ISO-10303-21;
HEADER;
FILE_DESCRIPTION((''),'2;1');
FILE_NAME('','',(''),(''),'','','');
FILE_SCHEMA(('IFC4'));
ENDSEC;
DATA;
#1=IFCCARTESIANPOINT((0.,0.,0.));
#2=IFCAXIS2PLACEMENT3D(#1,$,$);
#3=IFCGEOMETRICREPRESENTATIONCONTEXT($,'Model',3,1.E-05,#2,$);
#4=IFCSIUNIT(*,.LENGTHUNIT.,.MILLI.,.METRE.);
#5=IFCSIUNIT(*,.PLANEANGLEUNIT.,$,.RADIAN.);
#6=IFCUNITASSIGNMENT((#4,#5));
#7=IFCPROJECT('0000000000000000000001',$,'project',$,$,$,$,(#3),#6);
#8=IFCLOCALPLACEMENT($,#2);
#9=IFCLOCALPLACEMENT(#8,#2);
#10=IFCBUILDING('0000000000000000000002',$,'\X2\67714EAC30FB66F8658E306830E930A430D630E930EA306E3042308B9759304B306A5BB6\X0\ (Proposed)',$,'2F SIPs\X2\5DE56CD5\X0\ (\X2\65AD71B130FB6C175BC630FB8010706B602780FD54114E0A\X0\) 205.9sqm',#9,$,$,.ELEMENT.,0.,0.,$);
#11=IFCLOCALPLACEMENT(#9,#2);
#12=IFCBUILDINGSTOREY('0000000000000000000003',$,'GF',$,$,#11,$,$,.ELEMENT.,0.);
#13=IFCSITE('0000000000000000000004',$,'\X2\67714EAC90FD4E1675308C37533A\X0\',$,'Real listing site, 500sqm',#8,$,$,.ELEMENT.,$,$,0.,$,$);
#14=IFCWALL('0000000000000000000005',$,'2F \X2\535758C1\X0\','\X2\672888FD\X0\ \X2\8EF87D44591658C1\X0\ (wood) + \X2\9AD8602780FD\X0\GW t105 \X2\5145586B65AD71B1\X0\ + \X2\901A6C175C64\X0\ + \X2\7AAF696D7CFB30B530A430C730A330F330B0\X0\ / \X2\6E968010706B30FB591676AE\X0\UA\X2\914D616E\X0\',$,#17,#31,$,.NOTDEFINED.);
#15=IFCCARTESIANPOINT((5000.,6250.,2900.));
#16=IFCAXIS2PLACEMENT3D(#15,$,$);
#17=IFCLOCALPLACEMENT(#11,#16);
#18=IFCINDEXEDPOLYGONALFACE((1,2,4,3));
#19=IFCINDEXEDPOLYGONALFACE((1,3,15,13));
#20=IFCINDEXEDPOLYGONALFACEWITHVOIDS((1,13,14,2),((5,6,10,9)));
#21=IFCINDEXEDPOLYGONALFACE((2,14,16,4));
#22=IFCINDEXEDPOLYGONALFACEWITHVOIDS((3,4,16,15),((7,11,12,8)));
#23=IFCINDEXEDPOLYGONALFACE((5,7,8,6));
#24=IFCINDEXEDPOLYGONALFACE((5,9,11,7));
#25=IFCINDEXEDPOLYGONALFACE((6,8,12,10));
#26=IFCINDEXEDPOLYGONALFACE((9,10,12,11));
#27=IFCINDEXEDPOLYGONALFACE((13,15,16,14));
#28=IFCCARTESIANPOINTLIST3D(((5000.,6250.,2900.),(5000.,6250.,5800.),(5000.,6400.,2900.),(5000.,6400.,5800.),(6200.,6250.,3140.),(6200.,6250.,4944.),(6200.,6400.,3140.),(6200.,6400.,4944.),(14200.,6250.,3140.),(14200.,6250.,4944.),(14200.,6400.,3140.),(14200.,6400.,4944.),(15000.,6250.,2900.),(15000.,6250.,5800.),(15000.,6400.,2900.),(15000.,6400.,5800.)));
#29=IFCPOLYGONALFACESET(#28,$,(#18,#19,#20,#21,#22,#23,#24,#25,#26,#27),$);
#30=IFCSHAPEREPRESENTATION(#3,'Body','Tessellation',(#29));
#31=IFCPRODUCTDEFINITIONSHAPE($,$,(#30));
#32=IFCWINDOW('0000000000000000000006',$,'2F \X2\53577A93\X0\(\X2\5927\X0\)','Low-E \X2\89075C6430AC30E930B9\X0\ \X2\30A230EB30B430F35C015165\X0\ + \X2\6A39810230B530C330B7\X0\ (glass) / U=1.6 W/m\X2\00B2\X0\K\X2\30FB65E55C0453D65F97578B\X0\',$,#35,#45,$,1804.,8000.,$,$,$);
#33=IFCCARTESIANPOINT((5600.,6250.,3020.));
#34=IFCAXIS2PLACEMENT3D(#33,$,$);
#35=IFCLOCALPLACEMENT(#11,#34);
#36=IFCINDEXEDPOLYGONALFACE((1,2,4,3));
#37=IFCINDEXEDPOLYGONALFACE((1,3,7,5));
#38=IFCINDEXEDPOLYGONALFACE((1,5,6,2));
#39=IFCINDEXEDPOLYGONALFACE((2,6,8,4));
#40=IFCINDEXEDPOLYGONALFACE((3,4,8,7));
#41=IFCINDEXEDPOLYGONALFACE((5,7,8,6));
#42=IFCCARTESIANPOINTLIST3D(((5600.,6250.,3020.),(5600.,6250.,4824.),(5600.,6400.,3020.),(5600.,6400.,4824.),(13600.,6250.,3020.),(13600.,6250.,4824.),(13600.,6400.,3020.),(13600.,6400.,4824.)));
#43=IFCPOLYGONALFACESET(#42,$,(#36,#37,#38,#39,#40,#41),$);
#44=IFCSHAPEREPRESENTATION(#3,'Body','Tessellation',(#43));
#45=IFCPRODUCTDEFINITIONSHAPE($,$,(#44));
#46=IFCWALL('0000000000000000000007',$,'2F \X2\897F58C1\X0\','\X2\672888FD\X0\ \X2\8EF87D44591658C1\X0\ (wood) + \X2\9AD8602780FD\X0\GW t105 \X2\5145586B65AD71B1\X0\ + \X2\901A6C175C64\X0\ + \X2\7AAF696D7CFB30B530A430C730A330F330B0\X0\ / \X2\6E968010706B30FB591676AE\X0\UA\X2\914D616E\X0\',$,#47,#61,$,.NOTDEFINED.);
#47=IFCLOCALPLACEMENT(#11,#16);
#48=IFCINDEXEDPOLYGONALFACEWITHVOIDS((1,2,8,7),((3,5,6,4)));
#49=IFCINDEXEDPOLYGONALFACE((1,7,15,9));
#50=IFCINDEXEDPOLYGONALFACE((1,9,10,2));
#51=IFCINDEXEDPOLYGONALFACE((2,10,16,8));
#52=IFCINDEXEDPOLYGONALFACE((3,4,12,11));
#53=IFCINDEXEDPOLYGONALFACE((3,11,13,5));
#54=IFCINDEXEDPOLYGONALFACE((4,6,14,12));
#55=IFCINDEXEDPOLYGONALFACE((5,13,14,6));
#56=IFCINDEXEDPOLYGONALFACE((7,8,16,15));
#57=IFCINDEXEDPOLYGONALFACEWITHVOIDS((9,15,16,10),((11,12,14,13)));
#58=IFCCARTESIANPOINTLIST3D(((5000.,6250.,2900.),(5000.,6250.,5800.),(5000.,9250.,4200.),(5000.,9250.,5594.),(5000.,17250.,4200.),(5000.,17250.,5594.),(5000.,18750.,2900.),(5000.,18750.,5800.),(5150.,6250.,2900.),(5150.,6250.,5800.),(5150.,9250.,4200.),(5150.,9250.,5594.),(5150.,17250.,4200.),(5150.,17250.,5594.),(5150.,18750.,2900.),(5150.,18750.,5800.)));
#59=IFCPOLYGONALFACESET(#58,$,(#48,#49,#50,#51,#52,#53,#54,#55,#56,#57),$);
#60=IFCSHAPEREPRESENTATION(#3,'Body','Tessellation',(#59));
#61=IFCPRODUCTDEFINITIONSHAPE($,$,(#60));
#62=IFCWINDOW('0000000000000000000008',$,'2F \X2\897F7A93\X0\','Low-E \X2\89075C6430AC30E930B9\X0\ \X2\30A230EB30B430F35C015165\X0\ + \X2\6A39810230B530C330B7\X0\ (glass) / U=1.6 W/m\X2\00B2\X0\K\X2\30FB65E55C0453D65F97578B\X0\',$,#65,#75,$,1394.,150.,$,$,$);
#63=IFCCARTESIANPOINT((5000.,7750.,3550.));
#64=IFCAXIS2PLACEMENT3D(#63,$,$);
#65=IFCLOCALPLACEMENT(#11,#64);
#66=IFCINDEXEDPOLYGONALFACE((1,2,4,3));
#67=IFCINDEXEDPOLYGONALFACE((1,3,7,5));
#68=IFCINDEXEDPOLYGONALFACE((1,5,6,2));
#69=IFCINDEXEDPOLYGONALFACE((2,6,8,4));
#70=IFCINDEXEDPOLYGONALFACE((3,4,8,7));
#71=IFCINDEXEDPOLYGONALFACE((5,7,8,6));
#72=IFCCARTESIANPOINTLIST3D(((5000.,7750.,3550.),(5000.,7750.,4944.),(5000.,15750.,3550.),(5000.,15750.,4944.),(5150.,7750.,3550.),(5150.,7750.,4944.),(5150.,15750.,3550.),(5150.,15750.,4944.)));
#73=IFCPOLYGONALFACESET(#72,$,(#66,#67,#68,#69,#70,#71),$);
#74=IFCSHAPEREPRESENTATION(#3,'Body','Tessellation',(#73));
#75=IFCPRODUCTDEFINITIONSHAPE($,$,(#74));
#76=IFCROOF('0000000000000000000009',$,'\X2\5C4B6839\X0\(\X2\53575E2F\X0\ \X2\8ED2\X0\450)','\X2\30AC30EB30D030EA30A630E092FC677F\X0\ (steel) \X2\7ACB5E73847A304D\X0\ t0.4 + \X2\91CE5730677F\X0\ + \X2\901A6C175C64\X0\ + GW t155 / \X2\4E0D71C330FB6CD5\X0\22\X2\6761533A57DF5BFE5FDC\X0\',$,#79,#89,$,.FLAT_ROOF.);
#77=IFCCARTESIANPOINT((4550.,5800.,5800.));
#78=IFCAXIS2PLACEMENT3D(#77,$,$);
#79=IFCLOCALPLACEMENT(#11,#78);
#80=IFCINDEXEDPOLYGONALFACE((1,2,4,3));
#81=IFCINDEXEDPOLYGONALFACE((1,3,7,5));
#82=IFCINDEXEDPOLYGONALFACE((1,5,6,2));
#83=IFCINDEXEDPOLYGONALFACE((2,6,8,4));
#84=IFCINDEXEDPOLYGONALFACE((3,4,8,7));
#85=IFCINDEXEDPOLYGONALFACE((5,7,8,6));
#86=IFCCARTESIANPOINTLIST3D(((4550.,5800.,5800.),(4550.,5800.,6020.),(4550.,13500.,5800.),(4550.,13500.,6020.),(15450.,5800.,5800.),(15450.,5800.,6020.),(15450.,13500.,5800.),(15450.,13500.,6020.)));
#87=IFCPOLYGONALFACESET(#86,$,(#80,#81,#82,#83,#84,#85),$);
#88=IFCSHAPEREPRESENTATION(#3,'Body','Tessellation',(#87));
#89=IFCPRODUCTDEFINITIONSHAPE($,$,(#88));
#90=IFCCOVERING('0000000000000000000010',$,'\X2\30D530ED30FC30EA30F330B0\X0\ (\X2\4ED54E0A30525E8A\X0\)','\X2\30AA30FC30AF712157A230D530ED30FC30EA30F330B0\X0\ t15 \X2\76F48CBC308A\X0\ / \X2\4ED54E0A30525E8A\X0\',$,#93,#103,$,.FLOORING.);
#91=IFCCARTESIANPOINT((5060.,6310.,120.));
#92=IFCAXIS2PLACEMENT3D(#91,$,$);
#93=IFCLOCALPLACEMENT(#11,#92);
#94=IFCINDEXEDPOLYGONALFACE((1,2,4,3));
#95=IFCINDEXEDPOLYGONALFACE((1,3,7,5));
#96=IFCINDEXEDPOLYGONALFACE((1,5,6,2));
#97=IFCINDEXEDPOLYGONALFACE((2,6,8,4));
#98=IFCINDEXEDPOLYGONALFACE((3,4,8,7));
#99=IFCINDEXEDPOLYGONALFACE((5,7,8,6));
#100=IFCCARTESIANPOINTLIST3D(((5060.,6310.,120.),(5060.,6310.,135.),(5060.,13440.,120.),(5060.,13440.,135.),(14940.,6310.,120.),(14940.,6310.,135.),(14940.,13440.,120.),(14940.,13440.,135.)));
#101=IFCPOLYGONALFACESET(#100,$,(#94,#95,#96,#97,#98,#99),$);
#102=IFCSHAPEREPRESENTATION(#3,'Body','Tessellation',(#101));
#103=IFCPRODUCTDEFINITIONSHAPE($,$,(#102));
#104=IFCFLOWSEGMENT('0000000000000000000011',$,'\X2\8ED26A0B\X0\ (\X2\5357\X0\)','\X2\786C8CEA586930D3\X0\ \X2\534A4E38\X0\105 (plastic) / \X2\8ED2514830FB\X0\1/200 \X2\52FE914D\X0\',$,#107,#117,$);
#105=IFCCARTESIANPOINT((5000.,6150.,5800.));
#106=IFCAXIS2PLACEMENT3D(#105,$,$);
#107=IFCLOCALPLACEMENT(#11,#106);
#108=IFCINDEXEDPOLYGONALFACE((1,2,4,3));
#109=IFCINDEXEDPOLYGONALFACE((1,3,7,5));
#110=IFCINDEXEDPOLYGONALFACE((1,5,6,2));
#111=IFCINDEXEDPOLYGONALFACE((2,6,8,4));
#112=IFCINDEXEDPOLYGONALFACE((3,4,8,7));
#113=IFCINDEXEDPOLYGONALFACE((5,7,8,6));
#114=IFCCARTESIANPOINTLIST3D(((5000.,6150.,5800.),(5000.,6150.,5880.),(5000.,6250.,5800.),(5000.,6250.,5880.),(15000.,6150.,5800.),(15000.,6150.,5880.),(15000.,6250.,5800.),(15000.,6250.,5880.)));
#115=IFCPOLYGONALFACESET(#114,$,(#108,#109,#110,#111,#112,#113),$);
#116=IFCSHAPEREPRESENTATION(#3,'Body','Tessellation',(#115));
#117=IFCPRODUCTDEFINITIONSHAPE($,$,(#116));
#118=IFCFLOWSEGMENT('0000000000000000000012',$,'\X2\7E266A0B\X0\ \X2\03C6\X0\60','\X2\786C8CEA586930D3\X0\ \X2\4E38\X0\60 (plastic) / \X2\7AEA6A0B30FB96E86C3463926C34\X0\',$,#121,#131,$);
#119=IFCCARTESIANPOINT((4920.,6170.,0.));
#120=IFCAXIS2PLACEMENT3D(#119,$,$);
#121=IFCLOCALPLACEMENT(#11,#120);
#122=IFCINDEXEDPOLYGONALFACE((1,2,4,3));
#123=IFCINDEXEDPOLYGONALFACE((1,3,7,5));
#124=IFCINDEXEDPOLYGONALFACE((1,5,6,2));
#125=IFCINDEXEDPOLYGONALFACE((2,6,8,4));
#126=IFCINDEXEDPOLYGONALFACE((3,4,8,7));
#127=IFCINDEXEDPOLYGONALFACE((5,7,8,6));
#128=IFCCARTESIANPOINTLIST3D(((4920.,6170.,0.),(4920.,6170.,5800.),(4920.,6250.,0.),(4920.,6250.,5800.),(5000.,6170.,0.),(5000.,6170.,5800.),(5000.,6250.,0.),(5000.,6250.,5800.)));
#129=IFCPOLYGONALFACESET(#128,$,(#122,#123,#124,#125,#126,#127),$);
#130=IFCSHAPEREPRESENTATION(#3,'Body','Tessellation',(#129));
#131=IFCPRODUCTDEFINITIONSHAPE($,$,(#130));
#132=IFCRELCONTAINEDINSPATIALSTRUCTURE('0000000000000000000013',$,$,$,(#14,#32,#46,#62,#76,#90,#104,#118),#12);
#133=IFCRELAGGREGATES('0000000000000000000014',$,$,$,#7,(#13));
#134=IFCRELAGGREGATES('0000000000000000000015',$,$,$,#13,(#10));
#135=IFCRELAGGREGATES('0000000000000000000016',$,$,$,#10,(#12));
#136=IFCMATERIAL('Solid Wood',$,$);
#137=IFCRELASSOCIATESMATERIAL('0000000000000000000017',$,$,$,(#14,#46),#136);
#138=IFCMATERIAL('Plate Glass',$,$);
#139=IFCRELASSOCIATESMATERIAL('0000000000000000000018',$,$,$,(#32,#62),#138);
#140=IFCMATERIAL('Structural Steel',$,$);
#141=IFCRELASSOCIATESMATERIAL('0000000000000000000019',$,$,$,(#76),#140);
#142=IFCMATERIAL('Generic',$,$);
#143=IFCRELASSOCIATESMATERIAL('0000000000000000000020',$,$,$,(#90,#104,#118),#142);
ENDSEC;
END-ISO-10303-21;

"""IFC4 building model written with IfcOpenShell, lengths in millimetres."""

from ifc_helpers import new_model, si_unit, frame, frame_2d, origin, place, context, project, spatial, rectangle, extrude, material, element, fill, save


model = new_model("IFC4")

# Units and contexts
model_context = context("Model", 3, precision=1e-05, world=origin())
ifc_project = project(units=[si_unit("LENGTHUNIT", "METRE", prefix="MILLI"), si_unit("PLANEANGLEUNIT", "RADIAN")], contexts=[model_context])

# Site, building, storey
site_placement = place(None, origin())
site = spatial("IfcSite", under=ifc_project, at=site_placement, Name="東京都世田谷区", ObjectType="Real listing site, 500sqm", CompositionType="ELEMENT", RefElevation=0.0)
building_placement = place(site_placement, origin())
building = spatial("IfcBuilding", under=site, at=building_placement, Name="東京・書斎とライブラリのある静かな家 (Proposed)", ObjectType="2F SIPs工法 (断熱・気密・耐火性能向上) 205.9sqm", CompositionType="ELEMENT", ElevationOfRefHeight=0.0, ElevationOfTerrain=0.0)
storey_placement = place(building_placement, origin())
storey = spatial("IfcBuildingStorey", under=building, at=storey_placement, Name="GF", CompositionType="ELEMENT", Elevation=0.0)

# Shared definitions
ifc_material_1 = material(Name="Solid Wood")

# Shared definitions
ifc_material_2 = material(Name="Plate Glass")

# Walls, openings, windows
wall_1_placement = place(storey_placement, frame((5000.0, 6250.0, 2900.0)))
wall_1 = element("IfcWall", 1, at=wall_1_placement, inside=storey, material=ifc_material_1, Name="2F 南壁", Description="木製 軸組外壁 (wood) + 高性能GW t105 充填断熱 + 通気層 + 窯業系サイディング / 準耐火・外皮UA配慮", PredefinedType="NOTDEFINED", context=model_context, shape_type="SweptSolid", body=[
    extrude(rectangle(XDim=10000.0, YDim=150.0, at=frame_2d((5000.0, 75.0))), frame((5000.0, 6250.0, 2900.0)), (0.0, 0.0, 1.0), 2900.0),
])
opening_1_placement = place(storey_placement, frame((5600.0, 6250.0, 3020.0)))
opening_1 = element("IfcOpeningElement", 2, at=opening_1_placement, cuts=wall_1, PredefinedType="NOTDEFINED", context=model_context, shape_type="SweptSolid", body=[
    extrude(rectangle(XDim=8000.0, YDim=150.0, at=frame_2d((4000.0, 75.0))), frame((5600.0, 6250.0, 3020.0)), (0.0, 0.0, 1.0), 1804.0),
])
window_1_placement = place(storey_placement, frame((5600.0, 6250.0, 3020.0)))
window_1 = element("IfcWindow", 3, at=window_1_placement, inside=storey, material=ifc_material_2, Name="2F 南窓(大)", Description="Low-E 複層ガラス アルゴン封入 + 樹脂サッシ (glass) / U=1.6 W/m²K・日射取得型", OverallHeight=1804.0, OverallWidth=8000.0, context=model_context, shape_type="SweptSolid", body=[
    extrude(rectangle(XDim=8000.0, YDim=150.0, at=frame_2d((4000.0, 75.0))), frame((5600.0, 6250.0, 3020.0)), (0.0, 0.0, 1.0), 1804.0),
])
fill(opening_1, window_1)
wall_2_placement = place(storey_placement, frame((5000.0, 6250.0, 2900.0)))
wall_2 = element("IfcWall", 4, at=wall_2_placement, inside=storey, material=ifc_material_1, Name="2F 西壁", Description="木製 軸組外壁 (wood) + 高性能GW t105 充填断熱 + 通気層 + 窯業系サイディング / 準耐火・外皮UA配慮", PredefinedType="NOTDEFINED", context=model_context, shape_type="SweptSolid", body=[
    extrude(rectangle(XDim=150.0, YDim=12500.0, at=frame_2d((75.0, 6250.0))), frame((5000.0, 6250.0, 2900.0)), (0.0, 0.0, 1.0), 2900.0),
])
opening_2_placement = place(storey_placement, frame((5000.0, 7750.0, 3550.0)))
opening_2 = element("IfcOpeningElement", 5, at=opening_2_placement, cuts=wall_2, PredefinedType="NOTDEFINED", context=model_context, shape_type="SweptSolid", body=[
    extrude(rectangle(XDim=150.0, YDim=8000.0, at=frame_2d((75.0, 4000.0))), frame((5000.0, 7750.0, 3550.0)), (0.0, 0.0, 1.0), 1394.0),
])
window_2_placement = place(storey_placement, frame((5000.0, 7750.0, 3550.0)))
window_2 = element("IfcWindow", 6, at=window_2_placement, inside=storey, material=ifc_material_2, Name="2F 西窓", Description="Low-E 複層ガラス アルゴン封入 + 樹脂サッシ (glass) / U=1.6 W/m²K・日射取得型", OverallHeight=1394.0, OverallWidth=150.0, context=model_context, shape_type="SweptSolid", body=[
    extrude(rectangle(XDim=150.0, YDim=8000.0, at=frame_2d((75.0, 4000.0))), frame((5000.0, 7750.0, 3550.0)), (0.0, 0.0, 1.0), 1394.0),
])
fill(opening_2, window_2)

# Roof
ifc_material_3 = material(Name="Structural Steel")
for number, where, name in (
    (7, (4550.0, 5800.0, 5800.0), "屋根(南帯 軒450)"),
):
    element("IfcRoof", number, at=place(storey_placement, frame(where)), inside=storey, material=ifc_material_3, Name=name, Description="ガルバリウム鋼板 (steel) 立平葺き t0.4 + 野地板 + 通気層 + GW t155 / 不燃・法22条区域対応", PredefinedType="FLAT_ROOF", context=model_context, shape_type="SweptSolid", body=[
        extrude(rectangle(XDim=10900.0, YDim=7700.0, at=frame_2d((5450.0, 3850.0))), frame((4550.0, 5800.0, 5800.0)), (0.0, 0.0, 1.0), 220.0),
    ])

# Covering
ifc_material_4 = material(Name="Generic")
covering_placement = place(storey_placement, frame((5060.0, 6310.0, 120.0)))
element("IfcCovering", 8, at=covering_placement, inside=storey, material=ifc_material_4, Name="フローリング (仕上げ床)", Description="オーク無垢フローリング t15 直貼り / 仕上げ床", PredefinedType="FLOORING", context=model_context, shape_type="SweptSolid", body=[
    extrude(rectangle(XDim=9880.0, YDim=7130.0, at=frame_2d((4940.0, 3565.0))), frame((5060.0, 6310.0, 120.0)), (0.0, 0.0, 1.0), 15.0),
])

# Flow segments
flow_segment_1_placement = place(storey_placement, frame((5000.0, 6150.0, 5800.0)))
element("IfcFlowSegment", 9, at=flow_segment_1_placement, inside=storey, material=ifc_material_4, Name="軒樋 (南)", Description="硬質塩ビ 半丸105 (plastic) / 軒先・1/200 勾配", context=model_context, shape_type="SweptSolid", body=[
    extrude(rectangle(XDim=10000.0, YDim=100.0, at=frame_2d((5000.0, 50.0))), frame((5000.0, 6150.0, 5800.0)), (0.0, 0.0, 1.0), 80.0),
])
flow_segment_2_placement = place(storey_placement, frame((4920.0, 6170.0, 0.0)))
element("IfcFlowSegment", 10, at=flow_segment_2_placement, inside=storey, material=ifc_material_4, Name="縦樋 φ60", Description="硬質塩ビ 丸60 (plastic) / 竪樋・雨水排水", context=model_context, shape_type="SweptSolid", body=[
    extrude(rectangle(XDim=80.0, YDim=80.0, at=frame_2d((40.0, 40.0))), frame((4920.0, 6170.0, 0.0)), (0.0, 0.0, 1.0), 5800.0),
])

save(model, "model.ifc")
